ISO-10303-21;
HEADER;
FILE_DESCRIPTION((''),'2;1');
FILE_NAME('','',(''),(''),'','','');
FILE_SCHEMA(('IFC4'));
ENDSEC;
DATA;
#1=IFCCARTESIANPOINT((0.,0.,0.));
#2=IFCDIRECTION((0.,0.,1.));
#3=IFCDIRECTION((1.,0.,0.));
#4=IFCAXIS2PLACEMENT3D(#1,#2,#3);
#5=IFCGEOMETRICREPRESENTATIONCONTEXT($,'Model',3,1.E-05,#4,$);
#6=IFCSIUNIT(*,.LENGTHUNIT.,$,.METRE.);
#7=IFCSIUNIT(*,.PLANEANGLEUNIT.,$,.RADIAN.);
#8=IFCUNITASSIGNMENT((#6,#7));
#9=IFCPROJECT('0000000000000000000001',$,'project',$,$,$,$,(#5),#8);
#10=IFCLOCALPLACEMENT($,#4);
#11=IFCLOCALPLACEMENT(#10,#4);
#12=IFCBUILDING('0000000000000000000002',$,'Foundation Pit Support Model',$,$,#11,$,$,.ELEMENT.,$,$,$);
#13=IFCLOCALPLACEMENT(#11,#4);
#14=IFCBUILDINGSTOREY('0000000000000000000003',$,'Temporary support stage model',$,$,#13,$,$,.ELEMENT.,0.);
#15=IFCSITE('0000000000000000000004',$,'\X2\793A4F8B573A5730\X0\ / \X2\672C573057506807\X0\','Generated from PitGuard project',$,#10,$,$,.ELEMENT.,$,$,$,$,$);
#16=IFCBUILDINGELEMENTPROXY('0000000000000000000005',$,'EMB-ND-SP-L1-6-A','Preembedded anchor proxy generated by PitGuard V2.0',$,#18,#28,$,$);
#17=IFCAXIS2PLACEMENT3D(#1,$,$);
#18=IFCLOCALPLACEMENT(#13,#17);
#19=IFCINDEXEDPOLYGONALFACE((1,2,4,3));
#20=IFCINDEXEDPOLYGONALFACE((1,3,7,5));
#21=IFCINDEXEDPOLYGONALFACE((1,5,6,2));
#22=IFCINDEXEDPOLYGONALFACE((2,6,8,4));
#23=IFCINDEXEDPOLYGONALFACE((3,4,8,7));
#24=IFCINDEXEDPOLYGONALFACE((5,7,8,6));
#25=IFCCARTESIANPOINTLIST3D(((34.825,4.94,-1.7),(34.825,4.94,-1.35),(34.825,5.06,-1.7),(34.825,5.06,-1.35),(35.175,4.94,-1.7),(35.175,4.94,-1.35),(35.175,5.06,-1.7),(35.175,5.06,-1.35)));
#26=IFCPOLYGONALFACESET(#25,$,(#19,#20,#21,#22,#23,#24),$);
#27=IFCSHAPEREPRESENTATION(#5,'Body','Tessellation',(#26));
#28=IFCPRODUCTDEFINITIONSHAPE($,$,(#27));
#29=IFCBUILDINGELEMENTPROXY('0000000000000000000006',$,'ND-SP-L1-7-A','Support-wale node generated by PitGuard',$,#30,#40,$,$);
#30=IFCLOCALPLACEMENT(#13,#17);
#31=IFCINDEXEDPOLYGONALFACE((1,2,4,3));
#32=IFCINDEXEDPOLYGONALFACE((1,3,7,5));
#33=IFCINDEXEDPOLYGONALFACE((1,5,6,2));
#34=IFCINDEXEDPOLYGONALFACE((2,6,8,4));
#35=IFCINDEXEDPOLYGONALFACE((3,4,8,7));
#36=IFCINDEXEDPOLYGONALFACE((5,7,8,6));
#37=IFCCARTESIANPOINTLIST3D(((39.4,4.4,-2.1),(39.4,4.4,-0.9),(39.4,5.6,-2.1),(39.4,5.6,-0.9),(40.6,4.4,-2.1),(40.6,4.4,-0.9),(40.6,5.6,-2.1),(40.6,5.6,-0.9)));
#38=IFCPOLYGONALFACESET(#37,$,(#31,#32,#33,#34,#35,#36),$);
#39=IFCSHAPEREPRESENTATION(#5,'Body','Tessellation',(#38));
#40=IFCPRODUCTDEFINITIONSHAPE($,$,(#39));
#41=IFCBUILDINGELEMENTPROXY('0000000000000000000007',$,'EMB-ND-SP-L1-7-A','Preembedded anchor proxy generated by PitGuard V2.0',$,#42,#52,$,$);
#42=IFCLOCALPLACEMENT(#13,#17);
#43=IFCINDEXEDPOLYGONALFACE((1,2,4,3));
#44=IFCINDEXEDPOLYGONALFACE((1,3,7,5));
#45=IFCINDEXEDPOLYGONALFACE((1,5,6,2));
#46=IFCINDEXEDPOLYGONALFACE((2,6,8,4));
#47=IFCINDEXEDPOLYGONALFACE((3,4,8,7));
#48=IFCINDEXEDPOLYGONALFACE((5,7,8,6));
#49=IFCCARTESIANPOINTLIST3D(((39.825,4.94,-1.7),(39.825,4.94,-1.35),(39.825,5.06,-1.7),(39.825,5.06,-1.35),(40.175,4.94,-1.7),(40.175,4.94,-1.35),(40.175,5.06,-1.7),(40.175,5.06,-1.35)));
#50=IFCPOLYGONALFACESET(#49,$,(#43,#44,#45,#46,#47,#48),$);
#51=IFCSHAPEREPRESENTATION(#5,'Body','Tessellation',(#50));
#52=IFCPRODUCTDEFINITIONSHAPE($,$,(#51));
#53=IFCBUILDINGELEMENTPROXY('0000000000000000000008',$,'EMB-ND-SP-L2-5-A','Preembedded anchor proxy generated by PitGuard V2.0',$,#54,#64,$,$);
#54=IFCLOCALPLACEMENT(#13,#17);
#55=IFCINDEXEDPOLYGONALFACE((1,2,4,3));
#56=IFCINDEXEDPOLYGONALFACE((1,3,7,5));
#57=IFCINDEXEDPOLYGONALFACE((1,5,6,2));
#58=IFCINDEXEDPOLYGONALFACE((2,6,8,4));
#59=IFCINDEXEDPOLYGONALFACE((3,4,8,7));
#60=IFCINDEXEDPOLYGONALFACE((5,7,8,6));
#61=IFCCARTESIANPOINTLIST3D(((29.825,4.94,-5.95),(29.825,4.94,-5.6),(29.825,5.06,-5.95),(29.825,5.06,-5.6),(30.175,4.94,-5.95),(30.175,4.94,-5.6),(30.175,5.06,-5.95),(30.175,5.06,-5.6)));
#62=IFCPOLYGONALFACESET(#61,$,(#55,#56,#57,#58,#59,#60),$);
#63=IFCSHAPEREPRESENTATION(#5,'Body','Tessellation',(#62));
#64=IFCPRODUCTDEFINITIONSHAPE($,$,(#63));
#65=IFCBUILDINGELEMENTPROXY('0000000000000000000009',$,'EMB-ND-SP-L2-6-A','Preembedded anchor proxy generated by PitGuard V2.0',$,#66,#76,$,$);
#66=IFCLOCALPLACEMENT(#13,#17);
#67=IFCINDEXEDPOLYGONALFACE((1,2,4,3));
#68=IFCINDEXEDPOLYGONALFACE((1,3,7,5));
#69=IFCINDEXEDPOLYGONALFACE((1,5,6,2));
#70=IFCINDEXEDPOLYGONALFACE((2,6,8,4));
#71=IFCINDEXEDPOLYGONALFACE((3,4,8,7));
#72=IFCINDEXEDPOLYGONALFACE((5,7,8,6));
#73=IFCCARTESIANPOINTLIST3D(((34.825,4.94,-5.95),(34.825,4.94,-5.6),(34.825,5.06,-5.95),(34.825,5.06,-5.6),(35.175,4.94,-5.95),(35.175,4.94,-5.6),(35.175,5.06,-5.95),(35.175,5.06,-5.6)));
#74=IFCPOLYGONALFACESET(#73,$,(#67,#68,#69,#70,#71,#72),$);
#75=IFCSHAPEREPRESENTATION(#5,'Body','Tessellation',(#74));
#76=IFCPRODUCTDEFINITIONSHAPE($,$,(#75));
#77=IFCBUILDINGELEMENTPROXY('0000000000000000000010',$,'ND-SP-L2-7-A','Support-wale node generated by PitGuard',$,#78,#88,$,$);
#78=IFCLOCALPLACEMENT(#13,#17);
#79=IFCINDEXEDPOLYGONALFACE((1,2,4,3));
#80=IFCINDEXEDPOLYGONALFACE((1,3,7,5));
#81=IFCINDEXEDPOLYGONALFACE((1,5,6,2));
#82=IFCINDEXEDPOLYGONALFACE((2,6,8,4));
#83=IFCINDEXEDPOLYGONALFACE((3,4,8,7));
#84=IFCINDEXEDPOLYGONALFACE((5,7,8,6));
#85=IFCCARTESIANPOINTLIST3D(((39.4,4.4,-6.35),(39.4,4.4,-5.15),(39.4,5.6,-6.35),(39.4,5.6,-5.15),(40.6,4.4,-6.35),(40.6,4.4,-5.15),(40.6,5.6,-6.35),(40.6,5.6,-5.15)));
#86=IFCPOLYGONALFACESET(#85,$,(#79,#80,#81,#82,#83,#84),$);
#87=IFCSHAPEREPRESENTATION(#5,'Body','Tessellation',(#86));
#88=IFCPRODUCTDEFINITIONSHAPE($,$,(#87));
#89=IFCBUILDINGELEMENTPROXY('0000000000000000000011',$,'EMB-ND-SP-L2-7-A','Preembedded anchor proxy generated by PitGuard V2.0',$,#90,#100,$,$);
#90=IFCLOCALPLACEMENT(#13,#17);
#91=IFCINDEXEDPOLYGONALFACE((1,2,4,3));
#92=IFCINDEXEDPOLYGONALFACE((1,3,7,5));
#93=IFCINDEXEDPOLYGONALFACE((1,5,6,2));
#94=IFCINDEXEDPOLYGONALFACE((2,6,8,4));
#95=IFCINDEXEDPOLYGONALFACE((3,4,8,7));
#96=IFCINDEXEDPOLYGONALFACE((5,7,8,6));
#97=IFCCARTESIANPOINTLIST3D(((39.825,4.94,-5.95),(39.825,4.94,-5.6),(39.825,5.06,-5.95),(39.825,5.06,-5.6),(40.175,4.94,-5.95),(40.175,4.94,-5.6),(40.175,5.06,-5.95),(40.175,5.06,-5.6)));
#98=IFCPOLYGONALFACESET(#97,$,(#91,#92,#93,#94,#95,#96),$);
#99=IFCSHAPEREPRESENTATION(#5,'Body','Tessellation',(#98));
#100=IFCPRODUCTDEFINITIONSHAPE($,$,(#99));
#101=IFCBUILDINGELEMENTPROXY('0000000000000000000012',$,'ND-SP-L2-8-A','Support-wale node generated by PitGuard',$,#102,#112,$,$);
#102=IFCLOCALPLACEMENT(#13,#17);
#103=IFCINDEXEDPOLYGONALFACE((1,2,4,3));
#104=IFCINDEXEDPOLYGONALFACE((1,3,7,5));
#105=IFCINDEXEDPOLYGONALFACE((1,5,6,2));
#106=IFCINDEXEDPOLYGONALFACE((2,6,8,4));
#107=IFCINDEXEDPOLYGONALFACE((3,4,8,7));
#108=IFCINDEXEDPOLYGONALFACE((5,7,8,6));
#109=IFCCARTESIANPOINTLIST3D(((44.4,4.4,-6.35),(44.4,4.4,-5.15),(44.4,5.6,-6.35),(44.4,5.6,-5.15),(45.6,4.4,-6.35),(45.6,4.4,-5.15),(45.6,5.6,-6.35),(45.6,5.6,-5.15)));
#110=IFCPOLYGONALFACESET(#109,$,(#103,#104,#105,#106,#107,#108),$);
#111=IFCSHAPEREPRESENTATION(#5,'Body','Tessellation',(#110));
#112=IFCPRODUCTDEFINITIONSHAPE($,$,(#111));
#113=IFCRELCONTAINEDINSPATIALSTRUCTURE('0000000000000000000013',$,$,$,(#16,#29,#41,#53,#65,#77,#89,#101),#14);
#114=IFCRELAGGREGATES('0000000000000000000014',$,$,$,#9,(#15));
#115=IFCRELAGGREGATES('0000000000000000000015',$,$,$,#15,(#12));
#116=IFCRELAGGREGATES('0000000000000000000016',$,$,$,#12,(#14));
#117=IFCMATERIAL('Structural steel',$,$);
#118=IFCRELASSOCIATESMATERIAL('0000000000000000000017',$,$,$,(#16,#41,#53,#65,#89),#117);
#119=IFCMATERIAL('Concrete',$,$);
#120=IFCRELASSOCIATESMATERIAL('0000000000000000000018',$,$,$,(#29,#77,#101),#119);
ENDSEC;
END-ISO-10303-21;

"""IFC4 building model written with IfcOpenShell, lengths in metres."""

from ifc_helpers import new_model, si_unit, frame, origin_with_axes, origin_2d, place, context, project, spatial, rectangle, extrude, material, element, save


model = new_model("IFC4")

# Units and contexts
model_context = context("Model", 3, precision=1e-05, world=origin_with_axes())
ifc_project = project(units=[si_unit("LENGTHUNIT", "METRE"), si_unit("PLANEANGLEUNIT", "RADIAN")], contexts=[model_context])

# Site, building, storey
site_placement = place(None, origin_with_axes())
site = spatial("IfcSite", under=ifc_project, at=site_placement, Name="示例场地 / 本地坐标", Description="Generated from PitGuard project", CompositionType="ELEMENT")
building_placement = place(site_placement, origin_with_axes())
building = spatial("IfcBuilding", under=site, at=building_placement, Name="Foundation Pit Support Model", CompositionType="ELEMENT")
storey_placement = place(building_placement, origin_with_axes())
storey = spatial("IfcBuildingStorey", under=building, at=storey_placement, Name="Temporary support stage model", CompositionType="ELEMENT", Elevation=0.0)

# Shared definitions
ifc_material_1 = material(Name="Concrete")

# Shared definitions
ifc_material_2 = material(Name="Structural steel")

# Building element proxies
proxy_1_placement = place(storey_placement, frame((35.0, 5.0, -1.7), z_axis=(0.0, 0.0, 1.0), x_axis=(1.0, 0.0, 0.0)))
element("IfcBuildingElementProxy", 1, at=proxy_1_placement, inside=storey, material=ifc_material_2, Name="EMB-ND-SP-L1-6-A", Description="Preembedded anchor proxy generated by PitGuard V2.0", context=model_context, shape_type="SweptSolid", body=[
    extrude(rectangle(XDim=0.35, YDim=0.12, at=origin_2d()), origin_with_axes(), (0.0, 0.0, 1.0), 0.35),
])
proxy_2_placement = place(storey_placement, frame((40.0, 5.0, -2.1), z_axis=(0.0, 0.0, 1.0), x_axis=(1.0, 0.0, 0.0)))
element("IfcBuildingElementProxy", 2, at=proxy_2_placement, inside=storey, material=ifc_material_1, Name="ND-SP-L1-7-A", Description="Support-wale node generated by PitGuard", context=model_context, shape_type="SweptSolid", body=[
    extrude(rectangle(XDim=1.2, YDim=1.2, at=origin_2d()), origin_with_axes(), (0.0, 0.0, 1.0), 1.2),
])
for number, where, z_axis, x_axis, name in (
    (3, (40.0, 5.0, -1.7), (0.0, 0.0, 1.0), (1.0, 0.0, 0.0), "EMB-ND-SP-L1-7-A"),
    (4, (30.0, 5.0, -5.95), (0.0, 0.0, 1.0), (1.0, 0.0, 0.0), "EMB-ND-SP-L2-5-A"),
    (5, (35.0, 5.0, -5.95), (0.0, 0.0, 1.0), (1.0, 0.0, 0.0), "EMB-ND-SP-L2-6-A"),
):
    element("IfcBuildingElementProxy", number, at=place(storey_placement, frame(where, z_axis=z_axis, x_axis=x_axis)), inside=storey, material=ifc_material_2, Name=name, Description="Preembedded anchor proxy generated by PitGuard V2.0", context=model_context, shape_type="SweptSolid", body=[
        extrude(rectangle(XDim=0.35, YDim=0.12, at=origin_2d()), origin_with_axes(), (0.0, 0.0, 1.0), 0.35),
    ])
proxy_3_placement = place(storey_placement, frame((40.0, 5.0, -6.35), z_axis=(0.0, 0.0, 1.0), x_axis=(1.0, 0.0, 0.0)))
element("IfcBuildingElementProxy", 6, at=proxy_3_placement, inside=storey, material=ifc_material_1, Name="ND-SP-L2-7-A", Description="Support-wale node generated by PitGuard", context=model_context, shape_type="SweptSolid", body=[
    extrude(rectangle(XDim=1.2, YDim=1.2, at=origin_2d()), origin_with_axes(), (0.0, 0.0, 1.0), 1.2),
])
proxy_4_placement = place(storey_placement, frame((40.0, 5.0, -5.95), z_axis=(0.0, 0.0, 1.0), x_axis=(1.0, 0.0, 0.0)))
element("IfcBuildingElementProxy", 7, at=proxy_4_placement, inside=storey, material=ifc_material_2, Name="EMB-ND-SP-L2-7-A", Description="Preembedded anchor proxy generated by PitGuard V2.0", context=model_context, shape_type="SweptSolid", body=[
    extrude(rectangle(XDim=0.35, YDim=0.12, at=origin_2d()), origin_with_axes(), (0.0, 0.0, 1.0), 0.35),
])
proxy_5_placement = place(storey_placement, frame((45.0, 5.0, -6.35), z_axis=(0.0, 0.0, 1.0), x_axis=(1.0, 0.0, 0.0)))
element("IfcBuildingElementProxy", 8, at=proxy_5_placement, inside=storey, material=ifc_material_1, Name="ND-SP-L2-8-A", Description="Support-wale node generated by PitGuard", context=model_context, shape_type="SweptSolid", body=[
    extrude(rectangle(XDim=1.2, YDim=1.2, at=origin_2d()), origin_with_axes(), (0.0, 0.0, 1.0), 1.2),
])

save(model, "model.ifc")
